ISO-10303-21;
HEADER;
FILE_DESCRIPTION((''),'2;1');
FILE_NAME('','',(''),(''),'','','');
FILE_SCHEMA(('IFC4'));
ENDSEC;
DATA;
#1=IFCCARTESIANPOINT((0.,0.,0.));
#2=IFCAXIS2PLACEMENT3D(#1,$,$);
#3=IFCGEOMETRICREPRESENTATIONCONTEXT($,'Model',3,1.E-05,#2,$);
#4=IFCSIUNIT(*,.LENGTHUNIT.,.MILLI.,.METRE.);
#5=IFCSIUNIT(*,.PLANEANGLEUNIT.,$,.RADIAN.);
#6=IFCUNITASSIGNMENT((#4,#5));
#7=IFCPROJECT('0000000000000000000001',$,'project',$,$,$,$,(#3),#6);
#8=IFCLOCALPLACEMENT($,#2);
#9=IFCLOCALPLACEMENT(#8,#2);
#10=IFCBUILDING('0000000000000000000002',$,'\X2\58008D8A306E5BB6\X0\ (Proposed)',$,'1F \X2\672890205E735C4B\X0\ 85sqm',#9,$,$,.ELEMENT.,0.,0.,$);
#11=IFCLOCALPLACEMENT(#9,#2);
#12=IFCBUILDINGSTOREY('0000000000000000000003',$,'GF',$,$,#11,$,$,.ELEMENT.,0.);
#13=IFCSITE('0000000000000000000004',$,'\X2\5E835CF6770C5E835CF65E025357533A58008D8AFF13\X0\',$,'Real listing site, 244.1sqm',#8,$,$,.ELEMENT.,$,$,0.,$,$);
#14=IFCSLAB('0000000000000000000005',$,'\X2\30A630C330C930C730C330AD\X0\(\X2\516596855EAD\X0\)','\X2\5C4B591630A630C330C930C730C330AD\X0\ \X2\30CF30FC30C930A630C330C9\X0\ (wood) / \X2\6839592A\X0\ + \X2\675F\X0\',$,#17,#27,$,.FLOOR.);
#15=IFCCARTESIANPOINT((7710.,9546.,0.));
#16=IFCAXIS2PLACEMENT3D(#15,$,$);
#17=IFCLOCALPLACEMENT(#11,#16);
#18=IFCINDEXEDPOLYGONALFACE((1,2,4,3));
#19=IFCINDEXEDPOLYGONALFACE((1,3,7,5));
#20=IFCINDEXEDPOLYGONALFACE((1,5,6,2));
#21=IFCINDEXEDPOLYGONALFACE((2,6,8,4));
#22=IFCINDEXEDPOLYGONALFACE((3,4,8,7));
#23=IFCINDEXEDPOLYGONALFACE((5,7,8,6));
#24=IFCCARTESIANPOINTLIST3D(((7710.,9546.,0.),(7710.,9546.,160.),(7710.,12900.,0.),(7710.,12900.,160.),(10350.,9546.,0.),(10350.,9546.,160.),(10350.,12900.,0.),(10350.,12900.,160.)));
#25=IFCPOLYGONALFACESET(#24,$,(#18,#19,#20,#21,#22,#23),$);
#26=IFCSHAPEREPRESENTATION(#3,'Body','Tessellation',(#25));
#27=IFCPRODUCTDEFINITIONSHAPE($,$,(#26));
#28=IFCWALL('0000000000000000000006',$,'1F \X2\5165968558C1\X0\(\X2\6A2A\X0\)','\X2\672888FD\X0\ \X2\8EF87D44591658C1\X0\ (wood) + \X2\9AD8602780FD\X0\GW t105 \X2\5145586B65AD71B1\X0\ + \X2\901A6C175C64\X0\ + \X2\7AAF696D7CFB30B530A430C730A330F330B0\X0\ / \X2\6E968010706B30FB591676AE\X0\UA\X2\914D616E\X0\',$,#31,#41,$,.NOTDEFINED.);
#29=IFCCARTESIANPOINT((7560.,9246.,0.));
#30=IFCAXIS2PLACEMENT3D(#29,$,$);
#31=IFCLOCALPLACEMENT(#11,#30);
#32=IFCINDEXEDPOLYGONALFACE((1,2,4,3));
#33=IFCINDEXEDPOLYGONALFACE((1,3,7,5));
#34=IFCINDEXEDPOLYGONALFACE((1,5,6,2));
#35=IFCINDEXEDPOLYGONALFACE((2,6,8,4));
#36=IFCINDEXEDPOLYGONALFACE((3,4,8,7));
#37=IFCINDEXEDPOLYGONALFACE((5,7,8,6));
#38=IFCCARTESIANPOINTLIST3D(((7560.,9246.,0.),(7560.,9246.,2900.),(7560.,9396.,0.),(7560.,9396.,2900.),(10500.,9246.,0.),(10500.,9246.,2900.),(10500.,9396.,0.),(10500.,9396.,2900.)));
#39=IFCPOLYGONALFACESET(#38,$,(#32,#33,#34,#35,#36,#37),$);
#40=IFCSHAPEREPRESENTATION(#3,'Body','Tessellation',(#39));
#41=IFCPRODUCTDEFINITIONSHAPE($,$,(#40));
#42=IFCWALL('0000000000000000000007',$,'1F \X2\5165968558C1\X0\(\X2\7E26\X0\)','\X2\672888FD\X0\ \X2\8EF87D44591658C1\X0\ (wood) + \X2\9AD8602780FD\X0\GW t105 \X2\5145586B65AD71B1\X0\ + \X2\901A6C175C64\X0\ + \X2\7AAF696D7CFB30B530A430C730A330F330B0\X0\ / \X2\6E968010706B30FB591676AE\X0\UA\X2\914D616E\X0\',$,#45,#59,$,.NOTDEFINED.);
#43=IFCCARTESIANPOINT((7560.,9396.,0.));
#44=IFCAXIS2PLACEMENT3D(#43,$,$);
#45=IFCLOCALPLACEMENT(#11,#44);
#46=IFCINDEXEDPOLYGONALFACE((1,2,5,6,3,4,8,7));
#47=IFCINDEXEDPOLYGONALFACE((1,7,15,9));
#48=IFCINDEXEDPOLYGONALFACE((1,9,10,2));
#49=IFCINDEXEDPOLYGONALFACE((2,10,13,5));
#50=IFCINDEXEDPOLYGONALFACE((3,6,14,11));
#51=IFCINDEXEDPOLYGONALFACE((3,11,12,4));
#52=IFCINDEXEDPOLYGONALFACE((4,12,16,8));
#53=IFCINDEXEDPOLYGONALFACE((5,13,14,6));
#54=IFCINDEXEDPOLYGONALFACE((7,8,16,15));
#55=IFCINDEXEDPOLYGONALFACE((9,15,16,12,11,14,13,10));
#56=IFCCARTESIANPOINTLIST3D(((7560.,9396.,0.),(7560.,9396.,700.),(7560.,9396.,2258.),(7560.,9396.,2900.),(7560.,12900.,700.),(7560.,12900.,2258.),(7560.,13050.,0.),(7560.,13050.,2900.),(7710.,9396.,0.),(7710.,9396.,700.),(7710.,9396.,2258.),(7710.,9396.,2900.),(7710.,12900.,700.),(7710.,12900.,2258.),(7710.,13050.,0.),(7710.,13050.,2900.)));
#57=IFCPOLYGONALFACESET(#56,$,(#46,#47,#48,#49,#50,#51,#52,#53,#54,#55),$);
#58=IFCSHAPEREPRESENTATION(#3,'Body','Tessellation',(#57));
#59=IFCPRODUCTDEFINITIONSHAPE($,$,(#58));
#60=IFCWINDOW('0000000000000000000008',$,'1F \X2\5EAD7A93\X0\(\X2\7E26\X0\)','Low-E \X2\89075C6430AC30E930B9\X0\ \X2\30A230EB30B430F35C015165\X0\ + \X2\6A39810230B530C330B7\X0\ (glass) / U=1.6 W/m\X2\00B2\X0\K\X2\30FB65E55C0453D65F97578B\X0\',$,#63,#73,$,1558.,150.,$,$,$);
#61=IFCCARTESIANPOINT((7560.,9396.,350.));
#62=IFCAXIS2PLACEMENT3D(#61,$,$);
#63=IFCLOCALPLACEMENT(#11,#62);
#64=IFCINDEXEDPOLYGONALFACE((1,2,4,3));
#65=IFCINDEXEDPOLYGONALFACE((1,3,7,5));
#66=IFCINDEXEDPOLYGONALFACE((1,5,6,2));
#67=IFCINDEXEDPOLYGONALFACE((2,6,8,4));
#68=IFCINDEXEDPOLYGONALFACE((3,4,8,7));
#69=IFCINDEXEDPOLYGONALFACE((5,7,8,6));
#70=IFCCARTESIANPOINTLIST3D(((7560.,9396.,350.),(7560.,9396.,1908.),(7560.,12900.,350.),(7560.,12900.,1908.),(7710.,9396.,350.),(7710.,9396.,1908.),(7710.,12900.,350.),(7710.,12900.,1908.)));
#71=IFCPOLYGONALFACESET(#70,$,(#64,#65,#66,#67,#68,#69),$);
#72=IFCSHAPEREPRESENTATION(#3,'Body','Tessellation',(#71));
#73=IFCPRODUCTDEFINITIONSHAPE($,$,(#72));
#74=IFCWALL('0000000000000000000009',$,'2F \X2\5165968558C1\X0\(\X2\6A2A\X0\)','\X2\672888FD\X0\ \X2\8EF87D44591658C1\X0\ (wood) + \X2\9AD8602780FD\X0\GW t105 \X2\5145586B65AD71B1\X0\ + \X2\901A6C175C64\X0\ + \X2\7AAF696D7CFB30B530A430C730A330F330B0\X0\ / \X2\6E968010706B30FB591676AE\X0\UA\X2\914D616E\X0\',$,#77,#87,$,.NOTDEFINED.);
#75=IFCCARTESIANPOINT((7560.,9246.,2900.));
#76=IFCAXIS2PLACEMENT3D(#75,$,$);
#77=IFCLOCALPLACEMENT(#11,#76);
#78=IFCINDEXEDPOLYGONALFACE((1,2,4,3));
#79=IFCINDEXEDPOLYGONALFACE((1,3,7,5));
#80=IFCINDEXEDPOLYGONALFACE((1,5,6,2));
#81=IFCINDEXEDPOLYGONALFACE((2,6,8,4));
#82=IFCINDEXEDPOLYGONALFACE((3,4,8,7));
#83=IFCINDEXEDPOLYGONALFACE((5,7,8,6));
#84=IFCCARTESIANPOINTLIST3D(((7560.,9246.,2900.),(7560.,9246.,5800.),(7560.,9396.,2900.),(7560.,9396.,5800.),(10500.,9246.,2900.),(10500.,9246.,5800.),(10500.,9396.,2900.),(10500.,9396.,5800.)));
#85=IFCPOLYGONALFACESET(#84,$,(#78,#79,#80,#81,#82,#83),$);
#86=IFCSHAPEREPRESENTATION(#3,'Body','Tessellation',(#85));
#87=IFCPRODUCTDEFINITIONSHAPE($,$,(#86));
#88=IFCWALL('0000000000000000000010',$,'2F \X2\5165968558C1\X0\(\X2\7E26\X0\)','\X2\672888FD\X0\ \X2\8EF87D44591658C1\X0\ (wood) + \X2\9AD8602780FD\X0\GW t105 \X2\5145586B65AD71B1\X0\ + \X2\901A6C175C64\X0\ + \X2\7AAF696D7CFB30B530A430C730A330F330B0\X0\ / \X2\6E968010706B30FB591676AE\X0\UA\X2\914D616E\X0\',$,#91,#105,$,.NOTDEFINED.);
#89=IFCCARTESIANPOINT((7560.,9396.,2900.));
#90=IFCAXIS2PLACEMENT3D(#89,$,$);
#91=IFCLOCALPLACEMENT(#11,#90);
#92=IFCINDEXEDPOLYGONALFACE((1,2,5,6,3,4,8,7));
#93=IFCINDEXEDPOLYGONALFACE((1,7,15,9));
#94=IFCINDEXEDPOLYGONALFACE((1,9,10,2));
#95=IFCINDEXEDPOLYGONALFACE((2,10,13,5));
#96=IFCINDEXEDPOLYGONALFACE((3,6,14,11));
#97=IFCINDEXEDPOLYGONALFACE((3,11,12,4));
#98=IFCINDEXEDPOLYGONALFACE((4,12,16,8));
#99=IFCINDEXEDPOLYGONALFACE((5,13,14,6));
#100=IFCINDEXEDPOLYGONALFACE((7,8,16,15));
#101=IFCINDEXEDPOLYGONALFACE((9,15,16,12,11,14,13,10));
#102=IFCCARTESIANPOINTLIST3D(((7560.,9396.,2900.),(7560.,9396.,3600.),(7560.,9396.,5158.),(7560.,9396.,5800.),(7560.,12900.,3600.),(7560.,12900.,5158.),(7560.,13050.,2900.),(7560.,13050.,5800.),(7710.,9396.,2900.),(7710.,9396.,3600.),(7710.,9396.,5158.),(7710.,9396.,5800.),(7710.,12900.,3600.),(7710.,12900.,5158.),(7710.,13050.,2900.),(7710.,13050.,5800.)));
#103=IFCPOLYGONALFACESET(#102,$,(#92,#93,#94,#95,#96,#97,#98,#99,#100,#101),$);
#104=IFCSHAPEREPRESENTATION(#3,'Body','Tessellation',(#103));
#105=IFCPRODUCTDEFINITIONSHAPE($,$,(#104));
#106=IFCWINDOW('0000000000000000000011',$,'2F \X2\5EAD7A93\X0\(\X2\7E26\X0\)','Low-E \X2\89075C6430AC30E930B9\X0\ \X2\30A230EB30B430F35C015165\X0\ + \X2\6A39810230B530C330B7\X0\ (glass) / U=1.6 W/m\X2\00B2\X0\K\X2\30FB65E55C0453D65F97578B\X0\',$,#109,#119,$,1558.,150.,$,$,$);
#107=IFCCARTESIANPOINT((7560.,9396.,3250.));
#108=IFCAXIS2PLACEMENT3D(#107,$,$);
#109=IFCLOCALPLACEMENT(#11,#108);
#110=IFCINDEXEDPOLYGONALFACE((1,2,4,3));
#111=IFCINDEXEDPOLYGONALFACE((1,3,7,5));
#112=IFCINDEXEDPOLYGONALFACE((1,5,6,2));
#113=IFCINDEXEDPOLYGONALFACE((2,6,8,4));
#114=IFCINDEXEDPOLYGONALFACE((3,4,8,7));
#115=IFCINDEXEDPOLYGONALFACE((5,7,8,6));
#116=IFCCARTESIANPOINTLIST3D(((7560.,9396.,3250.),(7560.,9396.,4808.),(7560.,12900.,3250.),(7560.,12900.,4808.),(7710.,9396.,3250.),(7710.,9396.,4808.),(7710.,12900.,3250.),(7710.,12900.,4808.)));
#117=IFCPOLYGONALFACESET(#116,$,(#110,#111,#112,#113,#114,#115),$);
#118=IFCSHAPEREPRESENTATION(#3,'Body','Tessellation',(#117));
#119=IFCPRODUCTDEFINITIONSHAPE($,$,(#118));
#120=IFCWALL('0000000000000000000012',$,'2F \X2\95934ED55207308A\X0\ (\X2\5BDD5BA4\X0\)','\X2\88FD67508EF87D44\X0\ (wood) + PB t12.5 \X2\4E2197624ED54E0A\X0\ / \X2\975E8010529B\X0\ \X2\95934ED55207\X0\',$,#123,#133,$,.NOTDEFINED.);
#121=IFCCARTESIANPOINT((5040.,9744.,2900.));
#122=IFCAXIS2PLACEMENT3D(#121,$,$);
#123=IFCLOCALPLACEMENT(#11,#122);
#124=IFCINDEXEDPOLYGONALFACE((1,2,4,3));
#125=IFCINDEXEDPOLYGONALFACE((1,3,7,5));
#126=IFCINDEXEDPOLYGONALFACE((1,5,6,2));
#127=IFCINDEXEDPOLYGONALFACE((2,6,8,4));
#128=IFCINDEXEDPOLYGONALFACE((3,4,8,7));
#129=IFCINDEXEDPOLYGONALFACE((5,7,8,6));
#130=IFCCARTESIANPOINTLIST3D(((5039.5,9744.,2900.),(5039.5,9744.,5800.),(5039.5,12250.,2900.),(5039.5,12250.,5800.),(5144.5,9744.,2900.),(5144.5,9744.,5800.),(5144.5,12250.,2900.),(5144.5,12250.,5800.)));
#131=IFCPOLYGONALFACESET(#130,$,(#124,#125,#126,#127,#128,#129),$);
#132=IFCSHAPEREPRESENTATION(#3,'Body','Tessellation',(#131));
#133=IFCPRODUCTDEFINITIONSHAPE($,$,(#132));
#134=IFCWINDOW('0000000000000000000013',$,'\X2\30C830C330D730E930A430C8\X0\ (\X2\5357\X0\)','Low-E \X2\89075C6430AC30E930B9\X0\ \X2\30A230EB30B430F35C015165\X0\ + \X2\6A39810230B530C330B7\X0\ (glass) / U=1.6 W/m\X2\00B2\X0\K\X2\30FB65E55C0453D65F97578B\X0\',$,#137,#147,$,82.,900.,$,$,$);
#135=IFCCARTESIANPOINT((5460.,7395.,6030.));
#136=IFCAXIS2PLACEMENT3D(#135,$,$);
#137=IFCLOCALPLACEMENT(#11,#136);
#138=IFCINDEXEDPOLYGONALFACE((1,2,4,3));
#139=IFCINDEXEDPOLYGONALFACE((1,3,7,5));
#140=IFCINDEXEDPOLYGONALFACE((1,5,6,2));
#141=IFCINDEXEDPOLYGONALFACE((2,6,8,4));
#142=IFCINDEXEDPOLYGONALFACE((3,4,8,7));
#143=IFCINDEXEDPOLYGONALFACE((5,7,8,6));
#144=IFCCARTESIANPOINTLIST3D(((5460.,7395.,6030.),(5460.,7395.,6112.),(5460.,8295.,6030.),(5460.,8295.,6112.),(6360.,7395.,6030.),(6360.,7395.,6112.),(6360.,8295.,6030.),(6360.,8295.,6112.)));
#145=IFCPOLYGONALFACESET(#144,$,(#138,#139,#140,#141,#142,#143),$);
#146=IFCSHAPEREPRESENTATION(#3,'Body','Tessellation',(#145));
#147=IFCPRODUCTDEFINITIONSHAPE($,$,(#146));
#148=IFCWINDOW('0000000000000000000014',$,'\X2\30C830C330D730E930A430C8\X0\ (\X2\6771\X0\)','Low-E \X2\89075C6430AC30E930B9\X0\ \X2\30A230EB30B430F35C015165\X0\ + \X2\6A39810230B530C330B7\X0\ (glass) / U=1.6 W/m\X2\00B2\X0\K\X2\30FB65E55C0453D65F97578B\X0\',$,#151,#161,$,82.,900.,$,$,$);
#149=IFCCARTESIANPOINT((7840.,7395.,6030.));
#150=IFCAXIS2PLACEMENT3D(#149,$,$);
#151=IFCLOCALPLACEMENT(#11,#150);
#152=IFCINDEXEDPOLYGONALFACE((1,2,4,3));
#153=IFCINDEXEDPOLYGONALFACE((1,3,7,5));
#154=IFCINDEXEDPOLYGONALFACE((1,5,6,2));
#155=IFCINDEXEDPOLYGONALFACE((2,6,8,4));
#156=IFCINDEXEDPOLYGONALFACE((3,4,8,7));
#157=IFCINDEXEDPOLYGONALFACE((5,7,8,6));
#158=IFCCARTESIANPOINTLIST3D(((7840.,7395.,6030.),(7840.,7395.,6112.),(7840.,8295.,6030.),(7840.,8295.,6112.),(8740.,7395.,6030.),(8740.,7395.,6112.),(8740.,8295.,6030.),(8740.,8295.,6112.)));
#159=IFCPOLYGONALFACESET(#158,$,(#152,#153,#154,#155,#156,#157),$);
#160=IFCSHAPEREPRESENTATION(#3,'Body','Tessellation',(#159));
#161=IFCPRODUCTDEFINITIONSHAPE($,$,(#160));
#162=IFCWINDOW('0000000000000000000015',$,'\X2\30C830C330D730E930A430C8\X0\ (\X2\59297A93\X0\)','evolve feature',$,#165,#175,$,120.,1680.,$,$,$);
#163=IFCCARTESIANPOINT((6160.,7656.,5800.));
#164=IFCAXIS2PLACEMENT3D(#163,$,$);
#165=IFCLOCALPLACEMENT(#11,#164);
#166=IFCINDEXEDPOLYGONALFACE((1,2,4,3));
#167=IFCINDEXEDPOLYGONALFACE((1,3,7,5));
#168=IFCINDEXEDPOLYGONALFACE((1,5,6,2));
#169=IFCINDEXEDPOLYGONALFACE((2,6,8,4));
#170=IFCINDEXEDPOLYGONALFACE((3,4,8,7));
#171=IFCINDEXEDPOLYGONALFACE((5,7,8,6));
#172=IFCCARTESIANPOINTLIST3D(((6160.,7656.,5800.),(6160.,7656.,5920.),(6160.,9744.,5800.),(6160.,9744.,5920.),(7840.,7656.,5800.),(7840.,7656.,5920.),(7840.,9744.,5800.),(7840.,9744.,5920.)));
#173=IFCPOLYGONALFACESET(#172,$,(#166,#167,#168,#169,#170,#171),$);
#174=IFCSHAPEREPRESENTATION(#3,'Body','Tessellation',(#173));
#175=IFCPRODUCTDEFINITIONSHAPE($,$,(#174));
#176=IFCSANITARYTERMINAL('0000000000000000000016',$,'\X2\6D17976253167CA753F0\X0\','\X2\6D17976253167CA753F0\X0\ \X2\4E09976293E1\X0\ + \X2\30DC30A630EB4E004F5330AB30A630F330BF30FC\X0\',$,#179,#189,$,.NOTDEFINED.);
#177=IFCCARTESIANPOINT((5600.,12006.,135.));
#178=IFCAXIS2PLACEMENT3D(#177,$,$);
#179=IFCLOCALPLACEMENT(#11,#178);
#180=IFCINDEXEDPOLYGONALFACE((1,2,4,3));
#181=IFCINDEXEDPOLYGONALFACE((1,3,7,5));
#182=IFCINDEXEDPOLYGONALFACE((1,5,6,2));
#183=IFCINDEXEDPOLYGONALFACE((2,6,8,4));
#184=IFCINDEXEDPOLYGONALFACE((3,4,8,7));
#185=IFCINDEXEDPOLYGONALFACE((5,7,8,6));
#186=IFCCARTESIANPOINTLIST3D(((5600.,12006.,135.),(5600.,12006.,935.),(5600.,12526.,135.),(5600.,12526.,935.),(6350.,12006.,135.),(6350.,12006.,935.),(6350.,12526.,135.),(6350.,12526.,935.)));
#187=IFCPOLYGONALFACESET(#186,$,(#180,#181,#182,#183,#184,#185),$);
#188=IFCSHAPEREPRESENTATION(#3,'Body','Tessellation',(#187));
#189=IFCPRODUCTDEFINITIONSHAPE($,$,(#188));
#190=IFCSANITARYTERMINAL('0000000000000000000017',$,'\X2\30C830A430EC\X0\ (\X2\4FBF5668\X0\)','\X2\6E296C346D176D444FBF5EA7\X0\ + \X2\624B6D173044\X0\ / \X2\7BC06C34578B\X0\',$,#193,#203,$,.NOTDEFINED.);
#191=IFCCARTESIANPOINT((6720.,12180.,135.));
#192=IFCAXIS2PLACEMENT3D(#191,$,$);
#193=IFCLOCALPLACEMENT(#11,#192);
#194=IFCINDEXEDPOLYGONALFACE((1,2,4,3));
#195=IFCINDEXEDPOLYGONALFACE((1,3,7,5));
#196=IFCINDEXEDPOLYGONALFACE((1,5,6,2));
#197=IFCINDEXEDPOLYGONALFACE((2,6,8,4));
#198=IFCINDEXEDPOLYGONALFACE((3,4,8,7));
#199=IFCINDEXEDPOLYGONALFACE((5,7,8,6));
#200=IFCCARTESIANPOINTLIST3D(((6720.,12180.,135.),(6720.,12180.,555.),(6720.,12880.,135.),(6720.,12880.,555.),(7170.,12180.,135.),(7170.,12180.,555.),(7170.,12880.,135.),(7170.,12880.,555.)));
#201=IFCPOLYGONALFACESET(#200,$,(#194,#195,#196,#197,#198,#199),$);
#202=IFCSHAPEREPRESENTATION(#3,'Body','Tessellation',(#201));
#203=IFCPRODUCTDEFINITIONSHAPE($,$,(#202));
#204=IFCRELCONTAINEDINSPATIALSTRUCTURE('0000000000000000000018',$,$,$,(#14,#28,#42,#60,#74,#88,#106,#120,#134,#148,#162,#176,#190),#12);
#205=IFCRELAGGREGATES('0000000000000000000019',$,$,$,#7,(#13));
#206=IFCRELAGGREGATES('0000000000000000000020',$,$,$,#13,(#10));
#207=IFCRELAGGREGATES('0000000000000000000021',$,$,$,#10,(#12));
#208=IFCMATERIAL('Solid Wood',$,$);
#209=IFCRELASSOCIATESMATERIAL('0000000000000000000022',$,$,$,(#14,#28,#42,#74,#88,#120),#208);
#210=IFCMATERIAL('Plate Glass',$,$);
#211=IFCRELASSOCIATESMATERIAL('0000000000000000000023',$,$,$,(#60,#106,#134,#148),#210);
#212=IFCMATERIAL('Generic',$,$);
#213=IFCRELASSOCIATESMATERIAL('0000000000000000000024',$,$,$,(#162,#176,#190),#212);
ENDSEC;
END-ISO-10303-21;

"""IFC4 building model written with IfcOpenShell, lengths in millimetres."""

from ifc_helpers import new_model, si_unit, frame, frame_2d, origin, place, context, project, spatial, rectangle, extrude, material, element, fill, save


model = new_model("IFC4")

# Units and contexts
model_context = context("Model", 3, precision=1e-05, world=origin())
ifc_project = project(units=[si_unit("LENGTHUNIT", "METRE", prefix="MILLI"), si_unit("PLANEANGLEUNIT", "RADIAN")], contexts=[model_context])

# Site, building, storey
site_placement = place(None, origin())
site = spatial("IfcSite", under=ifc_project, at=site_placement, Name="広島県広島市南区堀越３", ObjectType="Real listing site, 244.1sqm", CompositionType="ELEMENT", RefElevation=0.0)
building_placement = place(site_placement, origin())
building = spatial("IfcBuilding", under=site, at=building_placement, Name="堀越の家 (Proposed)", ObjectType="1F 木造平屋 85sqm", CompositionType="ELEMENT", ElevationOfRefHeight=0.0, ElevationOfTerrain=0.0)
storey_placement = place(building_placement, origin())
storey = spatial("IfcBuildingStorey", under=building, at=storey_placement, Name="GF", CompositionType="ELEMENT", Elevation=0.0)

# Slab
ifc_material_1 = material(Name="Solid Wood")
slab_placement = place(storey_placement, frame((7710.0, 9546.0, 0.0)))
element("IfcSlab", 1, at=slab_placement, inside=storey, material=ifc_material_1, Name="ウッドデッキ(入隅庭)", Description="屋外ウッドデッキ ハードウッド (wood) / 根太 + 束", PredefinedType="FLOOR", context=model_context, shape_type="SweptSolid", body=[
    extrude(rectangle(XDim=2640.0, YDim=3354.0, at=frame_2d((1320.0, 1677.0))), frame((7710.0, 9546.0, 0.0)), (0.0, 0.0, 1.0), 160.0),
])

# Wall
wall_1_placement = place(storey_placement, frame((7560.0, 9246.0, 0.0)))
element("IfcWall", 2, at=wall_1_placement, inside=storey, material=ifc_material_1, Name="1F 入隅壁(横)", Description="木製 軸組外壁 (wood) + 高性能GW t105 充填断熱 + 通気層 + 窯業系サイディング / 準耐火・外皮UA配慮", PredefinedType="NOTDEFINED", context=model_context, shape_type="SweptSolid", body=[
    extrude(rectangle(XDim=2940.0, YDim=150.0, at=frame_2d((1470.0, 75.0))), frame((7560.0, 9246.0, 0.0)), (0.0, 0.0, 1.0), 2900.0),
])

# Wall, opening, window
wall_2_placement = place(storey_placement, frame((7560.0, 9396.0, 0.0)))
wall_2 = element("IfcWall", 3, at=wall_2_placement, inside=storey, material=ifc_material_1, Name="1F 入隅壁(縦)", Description="木製 軸組外壁 (wood) + 高性能GW t105 充填断熱 + 通気層 + 窯業系サイディング / 準耐火・外皮UA配慮", PredefinedType="NOTDEFINED", context=model_context, shape_type="SweptSolid", body=[
    extrude(rectangle(XDim=150.0, YDim=3654.0, at=frame_2d((75.0, 1827.0))), frame((7560.0, 9396.0, 0.0)), (0.0, 0.0, 1.0), 2900.0),
])
opening_1_placement = place(storey_placement, frame((7560.0, 9396.0, 350.0)))
opening_1 = element("IfcOpeningElement", 4, at=opening_1_placement, cuts=wall_2, PredefinedType="NOTDEFINED", context=model_context, shape_type="SweptSolid", body=[
    extrude(rectangle(XDim=150.0, YDim=3504.0, at=frame_2d((75.0, 1752.0))), frame((7560.0, 9396.0, 350.0)), (0.0, 0.0, 1.0), 1558.0),
])
ifc_material_2 = material(Name="Plate Glass")
window_1_placement = place(storey_placement, frame((7560.0, 9396.0, 350.0)))
window_1 = element("IfcWindow", 5, at=window_1_placement, inside=storey, material=ifc_material_2, Name="1F 庭窓(縦)", Description="Low-E 複層ガラス アルゴン封入 + 樹脂サッシ (glass) / U=1.6 W/m²K・日射取得型", OverallHeight=1558.0, OverallWidth=150.0, context=model_context, shape_type="SweptSolid", body=[
    extrude(rectangle(XDim=150.0, YDim=3504.0, at=frame_2d((75.0, 1752.0))), frame((7560.0, 9396.0, 350.0)), (0.0, 0.0, 1.0), 1558.0),
])
fill(opening_1, window_1)

# Wall
wall_3_placement = place(storey_placement, frame((7560.0, 9246.0, 2900.0)))
element("IfcWall", 6, at=wall_3_placement, inside=storey, material=ifc_material_1, Name="2F 入隅壁(横)", Description="木製 軸組外壁 (wood) + 高性能GW t105 充填断熱 + 通気層 + 窯業系サイディング / 準耐火・外皮UA配慮", PredefinedType="NOTDEFINED", context=model_context, shape_type="SweptSolid", body=[
    extrude(rectangle(XDim=2940.0, YDim=150.0, at=frame_2d((1470.0, 75.0))), frame((7560.0, 9246.0, 2900.0)), (0.0, 0.0, 1.0), 2900.0),
])

# Wall, opening, window
wall_4_placement = place(storey_placement, frame((7560.0, 9396.0, 2900.0)))
wall_4 = element("IfcWall", 7, at=wall_4_placement, inside=storey, material=ifc_material_1, Name="2F 入隅壁(縦)", Description="木製 軸組外壁 (wood) + 高性能GW t105 充填断熱 + 通気層 + 窯業系サイディング / 準耐火・外皮UA配慮", PredefinedType="NOTDEFINED", context=model_context, shape_type="SweptSolid", body=[
    extrude(rectangle(XDim=150.0, YDim=3654.0, at=frame_2d((75.0, 1827.0))), frame((7560.0, 9396.0, 2900.0)), (0.0, 0.0, 1.0), 2900.0),
])
opening_2_placement = place(storey_placement, frame((7560.0, 9396.0, 3250.0)))
opening_2 = element("IfcOpeningElement", 8, at=opening_2_placement, cuts=wall_4, PredefinedType="NOTDEFINED", context=model_context, shape_type="SweptSolid", body=[
    extrude(rectangle(XDim=150.0, YDim=3504.0, at=frame_2d((75.0, 1752.0))), frame((7560.0, 9396.0, 3250.0)), (0.0, 0.0, 1.0), 1558.0),
])
window_2_placement = place(storey_placement, frame((7560.0, 9396.0, 3250.0)))
window_2 = element("IfcWindow", 9, at=window_2_placement, inside=storey, material=ifc_material_2, Name="2F 庭窓(縦)", Description="Low-E 複層ガラス アルゴン封入 + 樹脂サッシ (glass) / U=1.6 W/m²K・日射取得型", OverallHeight=1558.0, OverallWidth=150.0, context=model_context, shape_type="SweptSolid", body=[
    extrude(rectangle(XDim=150.0, YDim=3504.0, at=frame_2d((75.0, 1752.0))), frame((7560.0, 9396.0, 3250.0)), (0.0, 0.0, 1.0), 1558.0),
])
fill(opening_2, window_2)

# Wall
wall_5_placement = place(storey_placement, frame((5040.0, 9744.0, 2900.0)))
element("IfcWall", 10, at=wall_5_placement, inside=storey, material=ifc_material_1, Name="2F 間仕切り (寝室)", Description="製材軸組 (wood) + PB t12.5 両面仕上 / 非耐力 間仕切", PredefinedType="NOTDEFINED", context=model_context, shape_type="SweptSolid", body=[
    extrude(rectangle(XDim=105.0, YDim=2506.0, at=frame_2d((52.0, 1253.0))), frame((5040.0, 9744.0, 2900.0)), (0.0, 0.0, 1.0), 2900.0),
])

# Windows
window_3_placement = place(storey_placement, frame((5460.0, 7395.0, 6030.0)))
element("IfcWindow", 11, at=window_3_placement, inside=storey, material=ifc_material_2, Name="トップライト (南)", Description="Low-E 複層ガラス アルゴン封入 + 樹脂サッシ (glass) / U=1.6 W/m²K・日射取得型", OverallHeight=82.0, OverallWidth=900.0, context=model_context, shape_type="SweptSolid", body=[
    extrude(rectangle(XDim=900.0, YDim=900.0, at=frame_2d((450.0, 450.0))), frame((5460.0, 7395.0, 6030.0)), (0.0, 0.0, 1.0), 82.0),
])
window_4_placement = place(storey_placement, frame((7840.0, 7395.0, 6030.0)))
element("IfcWindow", 12, at=window_4_placement, inside=storey, material=ifc_material_2, Name="トップライト (東)", Description="Low-E 複層ガラス アルゴン封入 + 樹脂サッシ (glass) / U=1.6 W/m²K・日射取得型", OverallHeight=82.0, OverallWidth=900.0, context=model_context, shape_type="SweptSolid", body=[
    extrude(rectangle(XDim=900.0, YDim=900.0, at=frame_2d((450.0, 450.0))), frame((7840.0, 7395.0, 6030.0)), (0.0, 0.0, 1.0), 82.0),
])
ifc_material_3 = material(Name="Generic")
window_5_placement = place(storey_placement, frame((6160.0, 7656.0, 5800.0)))
element("IfcWindow", 13, at=window_5_placement, inside=storey, material=ifc_material_3, Name="トップライト (天窓)", Description="evolve feature", OverallHeight=120.0, OverallWidth=1680.0, context=model_context, shape_type="SweptSolid", body=[
    extrude(rectangle(XDim=1680.0, YDim=2088.0, at=frame_2d((840.0, 1044.0))), frame((6160.0, 7656.0, 5800.0)), (0.0, 0.0, 1.0), 120.0),
])

# Sanitary terminals
sanitary_terminal_1_placement = place(storey_placement, frame((5600.0, 12006.0, 135.0)))
element("IfcSanitaryTerminal", 14, at=sanitary_terminal_1_placement, inside=storey, material=ifc_material_3, Name="洗面化粧台", Description="洗面化粧台 三面鏡 + ボウル一体カウンター", PredefinedType="NOTDEFINED", context=model_context, shape_type="SweptSolid", body=[
    extrude(rectangle(XDim=750.0, YDim=520.0, at=frame_2d((375.0, 260.0))), frame((5600.0, 12006.0, 135.0)), (0.0, 0.0, 1.0), 800.0),
])
sanitary_terminal_2_placement = place(storey_placement, frame((6720.0, 12180.0, 135.0)))
element("IfcSanitaryTerminal", 15, at=sanitary_terminal_2_placement, inside=storey, material=ifc_material_3, Name="トイレ (便器)", Description="温水洗浄便座 + 手洗い / 節水型", PredefinedType="NOTDEFINED", context=model_context, shape_type="SweptSolid", body=[
    extrude(rectangle(XDim=450.0, YDim=700.0, at=frame_2d((225.0, 350.0))), frame((6720.0, 12180.0, 135.0)), (0.0, 0.0, 1.0), 420.0),
])

save(model, "model.ifc")
